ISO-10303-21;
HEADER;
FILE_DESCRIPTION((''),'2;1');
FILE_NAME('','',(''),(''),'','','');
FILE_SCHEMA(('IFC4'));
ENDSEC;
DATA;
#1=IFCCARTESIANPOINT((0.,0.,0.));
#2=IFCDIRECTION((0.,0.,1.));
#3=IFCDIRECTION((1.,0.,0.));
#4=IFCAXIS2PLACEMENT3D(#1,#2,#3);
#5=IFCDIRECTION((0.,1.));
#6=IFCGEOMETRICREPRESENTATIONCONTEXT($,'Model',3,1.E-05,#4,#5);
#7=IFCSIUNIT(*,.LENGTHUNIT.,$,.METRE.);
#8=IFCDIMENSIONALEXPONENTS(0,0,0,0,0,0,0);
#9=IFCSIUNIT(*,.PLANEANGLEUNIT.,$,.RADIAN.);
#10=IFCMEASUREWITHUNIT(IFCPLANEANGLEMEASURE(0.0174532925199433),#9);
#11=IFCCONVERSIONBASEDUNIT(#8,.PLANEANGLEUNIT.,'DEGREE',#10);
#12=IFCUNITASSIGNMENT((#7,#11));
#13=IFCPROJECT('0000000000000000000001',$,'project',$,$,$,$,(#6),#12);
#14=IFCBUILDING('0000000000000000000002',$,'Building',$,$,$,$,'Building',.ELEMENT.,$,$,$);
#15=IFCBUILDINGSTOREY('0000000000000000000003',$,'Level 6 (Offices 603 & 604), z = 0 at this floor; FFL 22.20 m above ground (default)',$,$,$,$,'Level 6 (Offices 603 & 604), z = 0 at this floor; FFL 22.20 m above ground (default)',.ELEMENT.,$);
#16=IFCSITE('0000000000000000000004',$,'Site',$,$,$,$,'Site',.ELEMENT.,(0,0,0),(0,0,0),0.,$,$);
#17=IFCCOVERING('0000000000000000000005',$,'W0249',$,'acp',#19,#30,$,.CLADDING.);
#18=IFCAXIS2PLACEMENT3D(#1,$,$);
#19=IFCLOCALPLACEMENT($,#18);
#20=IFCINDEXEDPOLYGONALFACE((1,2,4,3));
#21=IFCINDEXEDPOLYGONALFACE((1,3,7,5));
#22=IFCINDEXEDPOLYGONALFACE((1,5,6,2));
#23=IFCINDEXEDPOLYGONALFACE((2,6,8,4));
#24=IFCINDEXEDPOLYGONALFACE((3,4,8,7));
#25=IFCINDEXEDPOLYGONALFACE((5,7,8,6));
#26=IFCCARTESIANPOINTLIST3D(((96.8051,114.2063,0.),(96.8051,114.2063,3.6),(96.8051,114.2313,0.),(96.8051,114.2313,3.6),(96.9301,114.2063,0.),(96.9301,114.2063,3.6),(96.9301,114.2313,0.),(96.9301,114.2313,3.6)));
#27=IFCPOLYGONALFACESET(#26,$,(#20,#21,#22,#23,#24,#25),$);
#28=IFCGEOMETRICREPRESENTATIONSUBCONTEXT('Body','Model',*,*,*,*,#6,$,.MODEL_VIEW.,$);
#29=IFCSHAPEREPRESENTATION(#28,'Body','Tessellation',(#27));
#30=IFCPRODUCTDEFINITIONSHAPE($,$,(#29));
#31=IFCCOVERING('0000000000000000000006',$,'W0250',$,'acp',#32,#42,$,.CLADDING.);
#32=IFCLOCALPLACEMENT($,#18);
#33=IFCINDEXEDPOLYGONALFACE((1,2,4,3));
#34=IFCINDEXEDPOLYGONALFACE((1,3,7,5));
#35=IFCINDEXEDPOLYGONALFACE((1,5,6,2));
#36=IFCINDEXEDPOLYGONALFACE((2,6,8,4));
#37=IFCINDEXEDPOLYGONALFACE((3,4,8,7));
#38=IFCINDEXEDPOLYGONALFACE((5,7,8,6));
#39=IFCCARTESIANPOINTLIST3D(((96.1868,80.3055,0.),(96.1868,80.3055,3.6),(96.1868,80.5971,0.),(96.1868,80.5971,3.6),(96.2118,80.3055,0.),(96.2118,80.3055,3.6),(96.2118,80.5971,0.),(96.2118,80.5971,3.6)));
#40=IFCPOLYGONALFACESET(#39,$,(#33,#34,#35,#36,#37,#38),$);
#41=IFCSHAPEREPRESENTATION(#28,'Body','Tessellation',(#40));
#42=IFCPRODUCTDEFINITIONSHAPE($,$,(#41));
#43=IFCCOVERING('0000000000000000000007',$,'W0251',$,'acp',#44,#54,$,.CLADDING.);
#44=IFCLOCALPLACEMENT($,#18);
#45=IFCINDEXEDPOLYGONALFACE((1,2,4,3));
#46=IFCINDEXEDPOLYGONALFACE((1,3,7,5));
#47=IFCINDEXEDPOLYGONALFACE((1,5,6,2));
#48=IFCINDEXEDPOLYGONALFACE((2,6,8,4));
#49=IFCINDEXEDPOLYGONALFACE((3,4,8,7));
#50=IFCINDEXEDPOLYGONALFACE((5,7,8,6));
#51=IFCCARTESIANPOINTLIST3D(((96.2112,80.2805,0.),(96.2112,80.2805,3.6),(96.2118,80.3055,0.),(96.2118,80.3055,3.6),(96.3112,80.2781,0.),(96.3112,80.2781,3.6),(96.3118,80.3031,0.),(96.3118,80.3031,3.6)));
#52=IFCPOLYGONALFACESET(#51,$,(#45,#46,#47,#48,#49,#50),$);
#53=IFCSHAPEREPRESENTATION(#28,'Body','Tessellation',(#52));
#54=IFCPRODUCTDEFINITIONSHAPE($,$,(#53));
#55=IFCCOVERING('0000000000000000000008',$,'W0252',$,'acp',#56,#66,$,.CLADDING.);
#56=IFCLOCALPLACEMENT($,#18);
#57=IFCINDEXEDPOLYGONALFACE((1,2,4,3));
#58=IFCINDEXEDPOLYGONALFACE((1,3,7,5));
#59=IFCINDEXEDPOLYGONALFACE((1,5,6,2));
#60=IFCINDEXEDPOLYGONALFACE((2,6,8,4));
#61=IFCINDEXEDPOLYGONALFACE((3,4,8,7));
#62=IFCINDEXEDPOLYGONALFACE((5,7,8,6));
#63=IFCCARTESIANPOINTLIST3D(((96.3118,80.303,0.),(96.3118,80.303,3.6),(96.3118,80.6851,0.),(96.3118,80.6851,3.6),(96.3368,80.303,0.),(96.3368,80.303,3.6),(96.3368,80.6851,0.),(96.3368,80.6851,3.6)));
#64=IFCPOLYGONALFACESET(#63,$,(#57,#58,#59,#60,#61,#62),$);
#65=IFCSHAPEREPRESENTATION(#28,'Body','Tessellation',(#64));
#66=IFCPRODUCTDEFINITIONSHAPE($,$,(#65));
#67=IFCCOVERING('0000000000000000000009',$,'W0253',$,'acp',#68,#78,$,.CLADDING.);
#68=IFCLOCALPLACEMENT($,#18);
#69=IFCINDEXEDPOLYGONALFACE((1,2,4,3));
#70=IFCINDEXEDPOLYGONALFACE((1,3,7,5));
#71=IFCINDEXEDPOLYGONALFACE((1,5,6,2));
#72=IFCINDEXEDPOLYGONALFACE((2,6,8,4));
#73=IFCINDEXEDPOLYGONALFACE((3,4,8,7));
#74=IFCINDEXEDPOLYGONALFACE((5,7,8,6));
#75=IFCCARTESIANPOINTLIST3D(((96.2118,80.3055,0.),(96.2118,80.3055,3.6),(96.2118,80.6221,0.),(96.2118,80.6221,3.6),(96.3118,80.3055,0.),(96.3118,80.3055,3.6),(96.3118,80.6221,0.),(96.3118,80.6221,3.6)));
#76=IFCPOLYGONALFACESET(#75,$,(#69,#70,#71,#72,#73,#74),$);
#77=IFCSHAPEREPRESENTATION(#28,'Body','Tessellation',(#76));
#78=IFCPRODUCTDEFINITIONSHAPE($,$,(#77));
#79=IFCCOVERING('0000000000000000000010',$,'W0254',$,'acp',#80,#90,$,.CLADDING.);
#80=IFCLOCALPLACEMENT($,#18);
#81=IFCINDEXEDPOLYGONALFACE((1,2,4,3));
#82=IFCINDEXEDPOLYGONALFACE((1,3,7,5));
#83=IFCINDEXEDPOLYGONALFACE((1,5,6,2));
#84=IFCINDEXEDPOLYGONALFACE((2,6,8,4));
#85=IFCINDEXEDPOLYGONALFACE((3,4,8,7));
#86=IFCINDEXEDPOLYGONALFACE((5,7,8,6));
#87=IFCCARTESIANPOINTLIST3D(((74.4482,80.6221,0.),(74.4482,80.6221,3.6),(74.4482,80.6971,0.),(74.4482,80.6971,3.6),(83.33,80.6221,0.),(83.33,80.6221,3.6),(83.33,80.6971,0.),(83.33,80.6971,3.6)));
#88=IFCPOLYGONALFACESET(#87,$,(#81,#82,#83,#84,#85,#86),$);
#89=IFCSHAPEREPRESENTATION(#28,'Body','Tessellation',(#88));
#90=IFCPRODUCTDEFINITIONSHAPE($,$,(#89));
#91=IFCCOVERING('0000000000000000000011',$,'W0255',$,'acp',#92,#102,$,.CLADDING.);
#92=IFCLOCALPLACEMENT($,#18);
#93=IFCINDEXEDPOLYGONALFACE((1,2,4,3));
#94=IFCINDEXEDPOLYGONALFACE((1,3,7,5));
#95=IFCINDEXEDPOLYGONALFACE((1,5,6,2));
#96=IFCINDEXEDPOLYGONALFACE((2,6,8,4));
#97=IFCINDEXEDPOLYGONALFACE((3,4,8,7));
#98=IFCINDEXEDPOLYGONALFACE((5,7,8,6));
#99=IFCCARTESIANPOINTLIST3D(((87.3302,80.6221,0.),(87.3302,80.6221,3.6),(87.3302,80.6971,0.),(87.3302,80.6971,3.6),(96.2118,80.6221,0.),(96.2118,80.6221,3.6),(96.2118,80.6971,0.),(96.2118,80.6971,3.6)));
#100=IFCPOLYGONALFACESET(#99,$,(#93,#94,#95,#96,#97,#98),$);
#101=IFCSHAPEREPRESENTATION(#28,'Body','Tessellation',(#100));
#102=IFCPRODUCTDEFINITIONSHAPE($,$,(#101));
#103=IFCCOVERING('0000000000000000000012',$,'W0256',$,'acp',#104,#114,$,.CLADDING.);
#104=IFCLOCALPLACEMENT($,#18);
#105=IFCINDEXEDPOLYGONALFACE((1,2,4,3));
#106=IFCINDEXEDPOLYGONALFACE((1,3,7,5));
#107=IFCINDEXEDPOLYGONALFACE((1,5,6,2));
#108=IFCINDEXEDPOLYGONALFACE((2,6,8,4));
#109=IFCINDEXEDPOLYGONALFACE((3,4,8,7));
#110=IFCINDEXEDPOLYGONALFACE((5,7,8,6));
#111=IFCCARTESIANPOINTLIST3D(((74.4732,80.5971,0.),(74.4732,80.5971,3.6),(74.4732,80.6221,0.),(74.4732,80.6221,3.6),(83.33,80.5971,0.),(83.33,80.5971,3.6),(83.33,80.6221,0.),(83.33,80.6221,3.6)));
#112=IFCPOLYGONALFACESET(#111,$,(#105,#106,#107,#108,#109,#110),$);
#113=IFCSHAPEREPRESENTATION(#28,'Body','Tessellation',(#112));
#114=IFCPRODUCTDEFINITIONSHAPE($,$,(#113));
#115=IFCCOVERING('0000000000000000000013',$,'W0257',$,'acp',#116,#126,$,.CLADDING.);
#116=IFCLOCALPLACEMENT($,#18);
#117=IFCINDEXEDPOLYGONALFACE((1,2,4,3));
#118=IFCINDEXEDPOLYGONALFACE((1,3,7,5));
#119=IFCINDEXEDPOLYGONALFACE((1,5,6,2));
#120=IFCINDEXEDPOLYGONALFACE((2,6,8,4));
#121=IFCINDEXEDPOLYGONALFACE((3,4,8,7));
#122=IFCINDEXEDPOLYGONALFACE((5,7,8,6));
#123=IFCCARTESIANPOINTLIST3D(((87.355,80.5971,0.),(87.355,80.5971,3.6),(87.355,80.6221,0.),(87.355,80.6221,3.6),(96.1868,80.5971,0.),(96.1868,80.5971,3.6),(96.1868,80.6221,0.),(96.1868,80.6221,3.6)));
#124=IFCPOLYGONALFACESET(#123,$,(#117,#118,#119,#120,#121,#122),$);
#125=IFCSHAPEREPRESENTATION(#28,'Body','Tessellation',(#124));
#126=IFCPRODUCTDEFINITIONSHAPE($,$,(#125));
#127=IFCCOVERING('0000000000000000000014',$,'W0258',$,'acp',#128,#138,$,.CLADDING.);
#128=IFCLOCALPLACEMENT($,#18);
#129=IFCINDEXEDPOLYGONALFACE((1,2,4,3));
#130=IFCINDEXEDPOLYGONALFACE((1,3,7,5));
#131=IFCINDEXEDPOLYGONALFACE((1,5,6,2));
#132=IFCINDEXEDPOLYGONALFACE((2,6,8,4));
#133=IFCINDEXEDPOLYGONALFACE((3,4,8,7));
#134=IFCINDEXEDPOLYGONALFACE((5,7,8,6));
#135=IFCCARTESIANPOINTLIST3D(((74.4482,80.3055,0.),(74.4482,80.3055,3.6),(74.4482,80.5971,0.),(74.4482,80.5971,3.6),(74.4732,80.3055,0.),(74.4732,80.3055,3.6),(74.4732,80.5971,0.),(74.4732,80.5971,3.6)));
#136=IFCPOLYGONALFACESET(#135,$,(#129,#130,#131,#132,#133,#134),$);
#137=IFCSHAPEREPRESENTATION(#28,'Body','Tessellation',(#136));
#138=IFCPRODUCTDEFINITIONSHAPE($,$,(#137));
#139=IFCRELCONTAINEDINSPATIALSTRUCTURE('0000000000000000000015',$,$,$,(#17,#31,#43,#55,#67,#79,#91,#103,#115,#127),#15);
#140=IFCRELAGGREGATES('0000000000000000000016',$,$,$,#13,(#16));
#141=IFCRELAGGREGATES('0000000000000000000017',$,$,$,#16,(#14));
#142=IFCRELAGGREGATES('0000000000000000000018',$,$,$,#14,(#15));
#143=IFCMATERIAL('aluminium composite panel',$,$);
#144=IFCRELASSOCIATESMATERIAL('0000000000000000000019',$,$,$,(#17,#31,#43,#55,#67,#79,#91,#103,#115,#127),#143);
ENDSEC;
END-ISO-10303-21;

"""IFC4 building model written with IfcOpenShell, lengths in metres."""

from ifc_helpers import new_model, entity, si_unit, converted_unit, direction, frame, frame_2d, origin_with_axes, origin_2d_with_axis, place, context, subcontext, project, spatial, rectangle, extrude, material, element, save


model = new_model("IFC4")

# Units and contexts
model_context = context("Model", 3, precision=1e-05, world=origin_with_axes(), true_north=direction((0.0, 1.0)))
body_context = subcontext(model_context, "Body", "Model", "MODEL_VIEW")
ifc_project = project(units=[si_unit("LENGTHUNIT", "METRE"), converted_unit("PLANEANGLEUNIT", "DEGREE", entity("IfcPlaneAngleMeasure", 0.0174532925199433), si_unit("PLANEANGLEUNIT", "RADIAN"), dimensions=[0, 0, 0, 0, 0, 0, 0])], contexts=[model_context])

# Site, building, storey
site = spatial("IfcSite", under=ifc_project, Name="Site", LongName="Site", CompositionType="ELEMENT", RefLatitude=(0, 0, 0), RefLongitude=(0, 0, 0), RefElevation=0.0)
building = spatial("IfcBuilding", under=site, Name="Building", LongName="Building", CompositionType="ELEMENT")
storey = spatial("IfcBuildingStorey", under=building, Name="Level 6 (Offices 603 & 604), z = 0 at this floor; FFL 22.20 m above ground (default)", LongName="Level 6 (Offices 603 & 604), z = 0 at this floor; FFL 22.20 m above ground (default)", CompositionType="ELEMENT")

# Shared definitions
placement = place(None, origin_with_axes())

# Coverings
ifc_material_1 = material(Name="aluminium composite panel")
element("IfcCovering", 1, at=placement, inside=storey, material=ifc_material_1, Name="W0249", ObjectType="acp", PredefinedType="CLADDING", context=body_context, shape_type="SweptSolid", body=[
    extrude(rectangle(XDim=0.125, YDim=0.025, at=origin_2d_with_axis()), frame((96.8676, 114.2188, 0.0), z_axis=(0.0, 0.0, 1.0), x_axis=(1.0, 0.0, 0.0)), (0.0, 0.0, 1.0), 3.6),
])
element("IfcCovering", 2, at=placement, inside=storey, material=ifc_material_1, Name="W0250", ObjectType="acp", PredefinedType="CLADDING", context=body_context, shape_type="SweptSolid", body=[
    extrude(rectangle(XDim=0.2916, YDim=0.025, at=frame_2d((0.0, 0.0), x_axis=(0.0, 1.0))), frame((96.1993, 80.4513, 0.0), z_axis=(0.0, 0.0, 1.0), x_axis=(1.0, 0.0, 0.0)), (0.0, 0.0, 1.0), 3.6),
])
element("IfcCovering", 3, at=placement, inside=storey, material=ifc_material_1, Name="W0251", ObjectType="acp", PredefinedType="CLADDING", context=body_context, shape_type="SweptSolid", body=[
    extrude(rectangle(XDim=0.1, YDim=0.025, at=frame_2d((0.0, 0.0), x_axis=(0.999712, -0.023993))), frame((96.2615, 80.2918, 0.0), z_axis=(0.0, 0.0, 1.0), x_axis=(1.0, 0.0, 0.0)), (0.0, 0.0, 1.0), 3.6),
])
element("IfcCovering", 4, at=placement, inside=storey, material=ifc_material_1, Name="W0252", ObjectType="acp", PredefinedType="CLADDING", context=body_context, shape_type="SweptSolid", body=[
    extrude(rectangle(XDim=0.3821, YDim=0.025, at=frame_2d((0.0, 0.0), x_axis=(0.0, 1.0))), frame((96.3243, 80.4941, 0.0), z_axis=(0.0, 0.0, 1.0), x_axis=(1.0, 0.0, 0.0)), (0.0, 0.0, 1.0), 3.6),
])
element("IfcCovering", 5, at=placement, inside=storey, material=ifc_material_1, Name="W0253", ObjectType="acp", PredefinedType="CLADDING", context=body_context, shape_type="SweptSolid", body=[
    extrude(rectangle(XDim=0.3166, YDim=0.1, at=frame_2d((0.0, 0.0), x_axis=(0.0, 1.0))), frame((96.2618, 80.4638, 0.0), z_axis=(0.0, 0.0, 1.0), x_axis=(1.0, 0.0, 0.0)), (0.0, 0.0, 1.0), 3.6),
])
element("IfcCovering", 6, at=placement, inside=storey, material=ifc_material_1, Name="W0254", ObjectType="acp", PredefinedType="CLADDING", context=body_context, shape_type="SweptSolid", body=[
    extrude(rectangle(XDim=8.8818, YDim=0.075, at=origin_2d_with_axis()), frame((78.8891, 80.6596, 0.0), z_axis=(0.0, 0.0, 1.0), x_axis=(1.0, 0.0, 0.0)), (0.0, 0.0, 1.0), 3.6),
])
element("IfcCovering", 7, at=placement, inside=storey, material=ifc_material_1, Name="W0255", ObjectType="acp", PredefinedType="CLADDING", context=body_context, shape_type="SweptSolid", body=[
    extrude(rectangle(XDim=8.8816, YDim=0.075, at=frame_2d((0.0, 0.0), x_axis=(1.0, 0.0))), frame((91.771, 80.6596, 0.0), z_axis=(0.0, 0.0, 1.0), x_axis=(1.0, 0.0, 0.0)), (0.0, 0.0, 1.0), 3.6),
])
element("IfcCovering", 8, at=placement, inside=storey, material=ifc_material_1, Name="W0256", ObjectType="acp", PredefinedType="CLADDING", context=body_context, shape_type="SweptSolid", body=[
    extrude(rectangle(XDim=8.8568, YDim=0.025, at=origin_2d_with_axis()), frame((78.9016, 80.6096, 0.0), z_axis=(0.0, 0.0, 1.0), x_axis=(1.0, 0.0, 0.0)), (0.0, 0.0, 1.0), 3.6),
])
element("IfcCovering", 9, at=placement, inside=storey, material=ifc_material_1, Name="W0257", ObjectType="acp", PredefinedType="CLADDING", context=body_context, shape_type="SweptSolid", body=[
    extrude(rectangle(XDim=8.8318, YDim=0.025, at=frame_2d((0.0, 0.0), x_axis=(1.0, 0.0))), frame((91.7709, 80.6096, 0.0), z_axis=(0.0, 0.0, 1.0), x_axis=(1.0, 0.0, 0.0)), (0.0, 0.0, 1.0), 3.6),
])
element("IfcCovering", 10, at=placement, inside=storey, material=ifc_material_1, Name="W0258", ObjectType="acp", PredefinedType="CLADDING", context=body_context, shape_type="SweptSolid", body=[
    extrude(rectangle(XDim=0.2916, YDim=0.025, at=frame_2d((0.0, 0.0), x_axis=(0.0, 1.0))), frame((74.4607, 80.4513, 0.0), z_axis=(0.0, 0.0, 1.0), x_axis=(1.0, 0.0, 0.0)), (0.0, 0.0, 1.0), 3.6),
])

save(model, "model.ifc")
